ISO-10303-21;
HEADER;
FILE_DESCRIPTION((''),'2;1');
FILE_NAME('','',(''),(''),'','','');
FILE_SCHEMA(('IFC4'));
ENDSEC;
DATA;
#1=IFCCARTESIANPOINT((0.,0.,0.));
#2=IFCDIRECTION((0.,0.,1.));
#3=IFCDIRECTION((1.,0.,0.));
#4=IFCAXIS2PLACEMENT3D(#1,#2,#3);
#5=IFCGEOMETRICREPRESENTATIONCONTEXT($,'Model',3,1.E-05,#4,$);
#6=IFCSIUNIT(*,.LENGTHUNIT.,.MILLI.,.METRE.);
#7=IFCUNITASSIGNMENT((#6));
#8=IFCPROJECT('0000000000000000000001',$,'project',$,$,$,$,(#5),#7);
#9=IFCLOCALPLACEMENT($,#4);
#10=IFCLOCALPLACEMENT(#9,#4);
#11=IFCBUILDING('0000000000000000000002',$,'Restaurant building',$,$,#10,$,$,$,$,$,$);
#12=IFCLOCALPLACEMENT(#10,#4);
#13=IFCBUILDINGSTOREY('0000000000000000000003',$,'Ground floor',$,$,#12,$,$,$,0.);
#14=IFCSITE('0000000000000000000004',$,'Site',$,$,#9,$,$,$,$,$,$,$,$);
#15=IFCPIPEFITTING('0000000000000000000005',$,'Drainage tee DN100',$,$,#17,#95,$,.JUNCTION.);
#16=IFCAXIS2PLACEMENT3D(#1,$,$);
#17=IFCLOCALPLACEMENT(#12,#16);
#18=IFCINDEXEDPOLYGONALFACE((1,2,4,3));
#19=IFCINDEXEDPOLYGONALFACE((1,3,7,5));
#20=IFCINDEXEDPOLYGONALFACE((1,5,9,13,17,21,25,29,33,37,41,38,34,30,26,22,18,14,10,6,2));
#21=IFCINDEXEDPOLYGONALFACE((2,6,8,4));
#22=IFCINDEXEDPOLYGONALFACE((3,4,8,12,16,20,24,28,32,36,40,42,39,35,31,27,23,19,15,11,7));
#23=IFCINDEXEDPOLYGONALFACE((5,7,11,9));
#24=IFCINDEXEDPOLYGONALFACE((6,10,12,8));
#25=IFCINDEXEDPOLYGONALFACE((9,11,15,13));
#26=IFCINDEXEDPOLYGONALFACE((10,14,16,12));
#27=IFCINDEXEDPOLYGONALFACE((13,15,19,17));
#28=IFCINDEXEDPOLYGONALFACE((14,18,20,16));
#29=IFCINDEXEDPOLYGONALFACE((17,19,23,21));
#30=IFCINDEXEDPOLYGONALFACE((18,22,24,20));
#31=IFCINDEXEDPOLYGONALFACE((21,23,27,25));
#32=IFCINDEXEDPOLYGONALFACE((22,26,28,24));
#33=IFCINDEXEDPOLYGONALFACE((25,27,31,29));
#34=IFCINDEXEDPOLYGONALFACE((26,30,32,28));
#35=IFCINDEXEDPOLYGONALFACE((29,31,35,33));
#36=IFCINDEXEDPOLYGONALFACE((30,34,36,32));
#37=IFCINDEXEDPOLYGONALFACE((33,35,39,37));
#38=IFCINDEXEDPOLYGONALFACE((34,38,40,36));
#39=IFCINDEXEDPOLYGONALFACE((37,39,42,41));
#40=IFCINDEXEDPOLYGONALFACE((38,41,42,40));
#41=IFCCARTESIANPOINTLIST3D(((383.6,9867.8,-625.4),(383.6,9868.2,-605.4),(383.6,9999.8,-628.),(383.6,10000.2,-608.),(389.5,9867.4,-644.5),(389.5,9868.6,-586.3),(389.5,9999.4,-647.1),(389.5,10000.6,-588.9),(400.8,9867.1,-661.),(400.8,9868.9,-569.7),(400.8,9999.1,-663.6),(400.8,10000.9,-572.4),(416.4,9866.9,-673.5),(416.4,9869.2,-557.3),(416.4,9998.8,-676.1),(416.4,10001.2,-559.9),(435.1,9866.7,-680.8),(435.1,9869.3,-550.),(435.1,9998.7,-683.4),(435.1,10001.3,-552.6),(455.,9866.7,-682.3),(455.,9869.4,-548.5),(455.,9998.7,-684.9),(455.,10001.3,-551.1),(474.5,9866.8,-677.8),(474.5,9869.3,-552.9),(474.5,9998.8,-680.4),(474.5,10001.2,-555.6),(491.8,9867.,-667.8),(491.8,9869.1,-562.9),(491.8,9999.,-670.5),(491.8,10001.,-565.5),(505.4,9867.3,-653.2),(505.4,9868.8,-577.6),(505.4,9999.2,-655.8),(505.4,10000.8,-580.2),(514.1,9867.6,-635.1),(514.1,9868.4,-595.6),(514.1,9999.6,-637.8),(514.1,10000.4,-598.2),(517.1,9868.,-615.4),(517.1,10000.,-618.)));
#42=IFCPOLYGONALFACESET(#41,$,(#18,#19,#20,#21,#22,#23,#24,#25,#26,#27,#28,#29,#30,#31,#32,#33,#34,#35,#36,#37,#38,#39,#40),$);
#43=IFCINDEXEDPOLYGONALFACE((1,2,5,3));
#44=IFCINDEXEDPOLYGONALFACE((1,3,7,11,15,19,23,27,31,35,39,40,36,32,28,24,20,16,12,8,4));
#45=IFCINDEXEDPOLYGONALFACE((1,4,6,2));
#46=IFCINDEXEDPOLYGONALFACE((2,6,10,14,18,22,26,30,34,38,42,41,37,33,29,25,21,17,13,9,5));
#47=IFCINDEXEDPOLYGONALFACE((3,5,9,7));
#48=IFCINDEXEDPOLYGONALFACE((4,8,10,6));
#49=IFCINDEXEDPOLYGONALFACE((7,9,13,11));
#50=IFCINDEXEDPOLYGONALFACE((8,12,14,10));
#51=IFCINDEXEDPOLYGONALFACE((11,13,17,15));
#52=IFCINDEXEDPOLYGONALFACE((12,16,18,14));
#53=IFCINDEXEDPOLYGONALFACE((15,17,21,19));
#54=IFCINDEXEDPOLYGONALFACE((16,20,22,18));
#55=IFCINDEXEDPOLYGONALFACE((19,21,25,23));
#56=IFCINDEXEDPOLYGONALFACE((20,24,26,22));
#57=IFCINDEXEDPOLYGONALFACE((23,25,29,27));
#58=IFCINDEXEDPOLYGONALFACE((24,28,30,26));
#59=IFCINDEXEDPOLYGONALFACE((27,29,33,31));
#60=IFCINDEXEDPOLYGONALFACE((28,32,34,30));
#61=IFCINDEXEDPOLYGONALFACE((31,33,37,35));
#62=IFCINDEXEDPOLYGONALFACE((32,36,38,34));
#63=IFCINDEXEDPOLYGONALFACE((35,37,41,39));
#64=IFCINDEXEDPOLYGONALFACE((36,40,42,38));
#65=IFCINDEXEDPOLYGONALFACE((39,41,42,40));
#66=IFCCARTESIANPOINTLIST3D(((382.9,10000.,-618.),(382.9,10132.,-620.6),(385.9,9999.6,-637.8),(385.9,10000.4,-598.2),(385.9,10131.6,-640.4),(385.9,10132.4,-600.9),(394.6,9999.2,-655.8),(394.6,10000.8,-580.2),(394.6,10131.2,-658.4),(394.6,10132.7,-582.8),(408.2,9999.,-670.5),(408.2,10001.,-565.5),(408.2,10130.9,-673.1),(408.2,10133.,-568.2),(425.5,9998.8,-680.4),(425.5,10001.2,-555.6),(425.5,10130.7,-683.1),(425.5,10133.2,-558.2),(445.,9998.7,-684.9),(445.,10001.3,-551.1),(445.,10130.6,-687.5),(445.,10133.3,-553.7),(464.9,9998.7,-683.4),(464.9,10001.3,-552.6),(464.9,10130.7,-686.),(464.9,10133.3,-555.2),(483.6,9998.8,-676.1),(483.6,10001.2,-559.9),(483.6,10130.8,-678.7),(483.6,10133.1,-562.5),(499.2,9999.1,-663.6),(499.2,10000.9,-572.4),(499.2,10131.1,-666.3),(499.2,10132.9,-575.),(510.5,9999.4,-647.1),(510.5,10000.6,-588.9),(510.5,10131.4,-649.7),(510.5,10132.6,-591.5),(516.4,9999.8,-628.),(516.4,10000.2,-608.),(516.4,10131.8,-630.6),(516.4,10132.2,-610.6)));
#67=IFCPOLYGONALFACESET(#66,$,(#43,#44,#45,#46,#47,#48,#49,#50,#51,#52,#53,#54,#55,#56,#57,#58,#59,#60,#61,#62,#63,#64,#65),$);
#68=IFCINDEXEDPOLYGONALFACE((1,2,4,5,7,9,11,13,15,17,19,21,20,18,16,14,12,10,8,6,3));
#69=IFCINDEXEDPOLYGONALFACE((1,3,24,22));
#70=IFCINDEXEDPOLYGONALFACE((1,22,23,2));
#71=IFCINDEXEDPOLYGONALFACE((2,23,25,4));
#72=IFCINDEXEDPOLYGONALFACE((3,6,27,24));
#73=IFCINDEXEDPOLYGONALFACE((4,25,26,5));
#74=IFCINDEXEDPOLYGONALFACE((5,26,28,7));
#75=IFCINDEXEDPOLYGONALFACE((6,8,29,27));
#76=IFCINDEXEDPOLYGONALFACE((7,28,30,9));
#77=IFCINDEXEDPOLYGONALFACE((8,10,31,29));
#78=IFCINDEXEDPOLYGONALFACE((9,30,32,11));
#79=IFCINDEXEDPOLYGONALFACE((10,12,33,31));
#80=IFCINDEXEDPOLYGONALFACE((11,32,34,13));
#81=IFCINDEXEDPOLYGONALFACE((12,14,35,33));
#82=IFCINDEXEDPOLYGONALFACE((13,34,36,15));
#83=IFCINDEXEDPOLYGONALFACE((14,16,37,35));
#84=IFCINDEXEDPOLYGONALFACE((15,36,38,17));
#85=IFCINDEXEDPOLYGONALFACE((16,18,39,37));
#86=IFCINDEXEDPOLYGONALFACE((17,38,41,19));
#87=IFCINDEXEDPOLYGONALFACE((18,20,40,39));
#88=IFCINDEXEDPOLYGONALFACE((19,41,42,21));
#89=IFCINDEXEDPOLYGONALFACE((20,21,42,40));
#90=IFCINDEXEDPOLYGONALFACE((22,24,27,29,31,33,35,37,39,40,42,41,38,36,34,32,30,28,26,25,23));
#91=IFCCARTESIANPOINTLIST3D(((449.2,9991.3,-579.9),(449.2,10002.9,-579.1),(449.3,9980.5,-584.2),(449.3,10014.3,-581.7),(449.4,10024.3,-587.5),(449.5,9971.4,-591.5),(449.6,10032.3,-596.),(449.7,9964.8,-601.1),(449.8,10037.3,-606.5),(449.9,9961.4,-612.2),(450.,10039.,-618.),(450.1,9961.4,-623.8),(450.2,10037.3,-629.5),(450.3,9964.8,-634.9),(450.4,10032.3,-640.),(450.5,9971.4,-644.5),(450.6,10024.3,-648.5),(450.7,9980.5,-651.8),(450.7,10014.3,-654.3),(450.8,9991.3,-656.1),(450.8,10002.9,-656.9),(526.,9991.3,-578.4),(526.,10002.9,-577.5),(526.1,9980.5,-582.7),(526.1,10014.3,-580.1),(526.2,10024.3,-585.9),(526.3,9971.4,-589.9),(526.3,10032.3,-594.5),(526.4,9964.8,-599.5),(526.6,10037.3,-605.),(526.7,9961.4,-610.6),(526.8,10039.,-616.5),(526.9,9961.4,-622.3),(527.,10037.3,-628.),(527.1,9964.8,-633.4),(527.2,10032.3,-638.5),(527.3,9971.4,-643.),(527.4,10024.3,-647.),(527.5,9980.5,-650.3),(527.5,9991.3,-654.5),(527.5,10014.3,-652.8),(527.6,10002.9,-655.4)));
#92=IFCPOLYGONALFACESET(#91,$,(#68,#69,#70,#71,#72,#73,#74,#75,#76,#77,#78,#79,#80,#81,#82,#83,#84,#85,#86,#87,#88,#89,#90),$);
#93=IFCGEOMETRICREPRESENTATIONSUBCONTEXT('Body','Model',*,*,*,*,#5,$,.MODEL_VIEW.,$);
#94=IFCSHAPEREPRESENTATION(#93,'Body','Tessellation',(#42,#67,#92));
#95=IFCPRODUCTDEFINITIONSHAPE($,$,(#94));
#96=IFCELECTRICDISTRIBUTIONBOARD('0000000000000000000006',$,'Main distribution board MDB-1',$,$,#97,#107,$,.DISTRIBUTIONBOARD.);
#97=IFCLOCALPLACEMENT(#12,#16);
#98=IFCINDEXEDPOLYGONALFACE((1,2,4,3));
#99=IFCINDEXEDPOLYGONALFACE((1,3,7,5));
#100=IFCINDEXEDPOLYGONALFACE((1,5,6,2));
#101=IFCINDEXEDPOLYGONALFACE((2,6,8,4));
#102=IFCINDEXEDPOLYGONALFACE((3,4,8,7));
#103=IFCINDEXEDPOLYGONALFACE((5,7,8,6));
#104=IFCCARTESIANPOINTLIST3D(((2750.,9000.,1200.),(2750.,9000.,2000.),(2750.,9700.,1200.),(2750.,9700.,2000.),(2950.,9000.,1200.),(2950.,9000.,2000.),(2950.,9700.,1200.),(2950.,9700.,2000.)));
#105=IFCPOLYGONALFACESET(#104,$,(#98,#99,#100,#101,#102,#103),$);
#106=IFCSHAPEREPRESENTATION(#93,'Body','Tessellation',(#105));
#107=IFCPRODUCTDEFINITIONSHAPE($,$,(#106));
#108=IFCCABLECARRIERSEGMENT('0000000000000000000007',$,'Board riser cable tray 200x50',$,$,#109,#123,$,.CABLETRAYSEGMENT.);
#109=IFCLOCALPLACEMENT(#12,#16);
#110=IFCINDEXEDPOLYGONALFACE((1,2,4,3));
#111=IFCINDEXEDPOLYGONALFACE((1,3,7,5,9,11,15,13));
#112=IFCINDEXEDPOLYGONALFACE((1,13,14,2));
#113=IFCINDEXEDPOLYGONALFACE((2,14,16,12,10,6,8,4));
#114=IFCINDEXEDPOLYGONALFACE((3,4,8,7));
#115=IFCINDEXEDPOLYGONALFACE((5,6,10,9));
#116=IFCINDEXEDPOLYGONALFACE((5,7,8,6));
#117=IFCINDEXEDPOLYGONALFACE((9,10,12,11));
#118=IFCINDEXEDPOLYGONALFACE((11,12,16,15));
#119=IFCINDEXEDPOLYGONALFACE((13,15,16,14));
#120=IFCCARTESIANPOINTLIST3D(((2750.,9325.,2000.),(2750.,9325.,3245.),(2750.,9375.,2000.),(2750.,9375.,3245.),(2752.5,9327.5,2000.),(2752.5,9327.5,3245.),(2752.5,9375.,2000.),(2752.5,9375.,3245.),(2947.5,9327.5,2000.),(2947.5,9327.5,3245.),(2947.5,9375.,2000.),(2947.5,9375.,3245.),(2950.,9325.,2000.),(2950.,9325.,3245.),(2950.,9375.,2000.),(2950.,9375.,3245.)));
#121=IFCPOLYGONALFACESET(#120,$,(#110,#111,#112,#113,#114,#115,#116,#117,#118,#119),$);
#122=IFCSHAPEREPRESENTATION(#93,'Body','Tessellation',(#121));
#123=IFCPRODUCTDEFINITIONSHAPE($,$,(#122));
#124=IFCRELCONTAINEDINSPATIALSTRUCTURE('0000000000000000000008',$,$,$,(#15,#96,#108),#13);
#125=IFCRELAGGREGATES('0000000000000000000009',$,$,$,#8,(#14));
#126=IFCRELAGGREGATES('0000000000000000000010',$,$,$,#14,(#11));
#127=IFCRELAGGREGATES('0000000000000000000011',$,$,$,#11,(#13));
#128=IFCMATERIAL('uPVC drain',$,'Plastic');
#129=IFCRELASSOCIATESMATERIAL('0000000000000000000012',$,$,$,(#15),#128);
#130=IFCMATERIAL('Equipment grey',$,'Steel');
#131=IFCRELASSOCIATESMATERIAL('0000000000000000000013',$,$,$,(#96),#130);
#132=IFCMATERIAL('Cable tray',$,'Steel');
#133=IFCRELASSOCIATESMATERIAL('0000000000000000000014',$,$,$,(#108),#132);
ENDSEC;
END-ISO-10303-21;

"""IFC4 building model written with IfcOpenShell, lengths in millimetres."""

from ifc_helpers import new_model, si_unit, frame, origin, origin_with_axes, origin_2d, place, context, subcontext, project, spatial, polyline, rectangle, circle, outline, extrude, material, element, save


model = new_model("IFC4")

# Units and contexts
model_context = context("Model", 3, precision=1e-05, world=origin_with_axes())
body_context = subcontext(model_context, "Body", "Model", "MODEL_VIEW")
ifc_project = project(units=[si_unit("LENGTHUNIT", "METRE", prefix="MILLI")], contexts=[model_context])

# Site, building, storey
site_placement = place(None, origin_with_axes())
site = spatial("IfcSite", under=ifc_project, at=site_placement, Name="Site")
building_placement = place(site_placement, origin_with_axes())
building = spatial("IfcBuilding", under=site, at=building_placement, Name="Restaurant building")
storey_placement = place(building_placement, origin_with_axes())
storey = spatial("IfcBuildingStorey", under=building, at=storey_placement, Name="Ground floor", Elevation=0.0)

# Shared definitions
ifc_material_1 = material(Name="uPVC drain", Category="Plastic")

# Pipe fitting
pipe_fitting_1_placement = place(storey_placement, frame((450.0, 10000.0, -618.0)))
element("IfcPipeFitting", 1, at=pipe_fitting_1_placement, inside=storey, material=ifc_material_1, Name="Drainage tee DN100", PredefinedType="JUNCTION", context=body_context, shape_type="SweptSolid", body=[
    extrude(circle(Radius=67.1, at=origin_2d()), frame((0.0, 0.0, 0.0), z_axis=(0.0, -0.9998, 0.019996), x_axis=(1.0, 0.0, 0.0)), (0.0, 0.0, 1.0), 132.0),
    extrude(circle(Radius=67.1, at=origin_2d()), frame((0.0, 0.0, 0.0), z_axis=(0.0, 0.9998, -0.019996), x_axis=(-1.0, 0.0, 0.0)), (0.0, 0.0, 1.0), 132.0),
    extrude(circle(Radius=39.0, at=origin_2d()), frame((0.0, 0.0, 0.0), z_axis=(0.9998, 0.0, 0.019996), x_axis=(0.0, 1.0, 0.0)), (0.0, 0.0, 1.0), 76.8),
])

# Electric distribution board
ifc_material_2 = material(Name="Equipment grey", Category="Steel")
electric_distribution_board_placement = place(storey_placement, frame((2850.0, 9350.0, 0.0)))
element("IfcElectricDistributionBoard", 2, at=electric_distribution_board_placement, inside=storey, material=ifc_material_2, Name="Main distribution board MDB-1", PredefinedType="DISTRIBUTIONBOARD", context=body_context, shape_type="SweptSolid", body=[
    extrude(rectangle(XDim=200.0, YDim=700.0, at=origin_2d()), frame((0.0, 0.0, 1200.0)), (0.0, 0.0, 1.0), 800.0),
])

# Cable carrier segment
ifc_material_3 = material(Name="Cable tray", Category="Steel")
cable_carrier_segment_placement = place(storey_placement, frame((2850.0, 9350.0, 2000.0)))
element("IfcCableCarrierSegment", 3, at=cable_carrier_segment_placement, inside=storey, material=ifc_material_3, Name="Board riser cable tray 200x50", PredefinedType="CABLETRAYSEGMENT", context=body_context, shape_type="SweptSolid", body=[
    extrude(outline(polyline([(-100.0, -25.0), (100.0, -25.0), (100.0, 25.0), (97.5, 25.0), (97.5, -22.5), (-97.5, -22.5), (-97.5, 25.0), (-100.0, 25.0), (-100.0, -25.0)])), origin(), (0.0, 0.0, 1.0), 1245.0),
])

save(model, "model.ifc")
